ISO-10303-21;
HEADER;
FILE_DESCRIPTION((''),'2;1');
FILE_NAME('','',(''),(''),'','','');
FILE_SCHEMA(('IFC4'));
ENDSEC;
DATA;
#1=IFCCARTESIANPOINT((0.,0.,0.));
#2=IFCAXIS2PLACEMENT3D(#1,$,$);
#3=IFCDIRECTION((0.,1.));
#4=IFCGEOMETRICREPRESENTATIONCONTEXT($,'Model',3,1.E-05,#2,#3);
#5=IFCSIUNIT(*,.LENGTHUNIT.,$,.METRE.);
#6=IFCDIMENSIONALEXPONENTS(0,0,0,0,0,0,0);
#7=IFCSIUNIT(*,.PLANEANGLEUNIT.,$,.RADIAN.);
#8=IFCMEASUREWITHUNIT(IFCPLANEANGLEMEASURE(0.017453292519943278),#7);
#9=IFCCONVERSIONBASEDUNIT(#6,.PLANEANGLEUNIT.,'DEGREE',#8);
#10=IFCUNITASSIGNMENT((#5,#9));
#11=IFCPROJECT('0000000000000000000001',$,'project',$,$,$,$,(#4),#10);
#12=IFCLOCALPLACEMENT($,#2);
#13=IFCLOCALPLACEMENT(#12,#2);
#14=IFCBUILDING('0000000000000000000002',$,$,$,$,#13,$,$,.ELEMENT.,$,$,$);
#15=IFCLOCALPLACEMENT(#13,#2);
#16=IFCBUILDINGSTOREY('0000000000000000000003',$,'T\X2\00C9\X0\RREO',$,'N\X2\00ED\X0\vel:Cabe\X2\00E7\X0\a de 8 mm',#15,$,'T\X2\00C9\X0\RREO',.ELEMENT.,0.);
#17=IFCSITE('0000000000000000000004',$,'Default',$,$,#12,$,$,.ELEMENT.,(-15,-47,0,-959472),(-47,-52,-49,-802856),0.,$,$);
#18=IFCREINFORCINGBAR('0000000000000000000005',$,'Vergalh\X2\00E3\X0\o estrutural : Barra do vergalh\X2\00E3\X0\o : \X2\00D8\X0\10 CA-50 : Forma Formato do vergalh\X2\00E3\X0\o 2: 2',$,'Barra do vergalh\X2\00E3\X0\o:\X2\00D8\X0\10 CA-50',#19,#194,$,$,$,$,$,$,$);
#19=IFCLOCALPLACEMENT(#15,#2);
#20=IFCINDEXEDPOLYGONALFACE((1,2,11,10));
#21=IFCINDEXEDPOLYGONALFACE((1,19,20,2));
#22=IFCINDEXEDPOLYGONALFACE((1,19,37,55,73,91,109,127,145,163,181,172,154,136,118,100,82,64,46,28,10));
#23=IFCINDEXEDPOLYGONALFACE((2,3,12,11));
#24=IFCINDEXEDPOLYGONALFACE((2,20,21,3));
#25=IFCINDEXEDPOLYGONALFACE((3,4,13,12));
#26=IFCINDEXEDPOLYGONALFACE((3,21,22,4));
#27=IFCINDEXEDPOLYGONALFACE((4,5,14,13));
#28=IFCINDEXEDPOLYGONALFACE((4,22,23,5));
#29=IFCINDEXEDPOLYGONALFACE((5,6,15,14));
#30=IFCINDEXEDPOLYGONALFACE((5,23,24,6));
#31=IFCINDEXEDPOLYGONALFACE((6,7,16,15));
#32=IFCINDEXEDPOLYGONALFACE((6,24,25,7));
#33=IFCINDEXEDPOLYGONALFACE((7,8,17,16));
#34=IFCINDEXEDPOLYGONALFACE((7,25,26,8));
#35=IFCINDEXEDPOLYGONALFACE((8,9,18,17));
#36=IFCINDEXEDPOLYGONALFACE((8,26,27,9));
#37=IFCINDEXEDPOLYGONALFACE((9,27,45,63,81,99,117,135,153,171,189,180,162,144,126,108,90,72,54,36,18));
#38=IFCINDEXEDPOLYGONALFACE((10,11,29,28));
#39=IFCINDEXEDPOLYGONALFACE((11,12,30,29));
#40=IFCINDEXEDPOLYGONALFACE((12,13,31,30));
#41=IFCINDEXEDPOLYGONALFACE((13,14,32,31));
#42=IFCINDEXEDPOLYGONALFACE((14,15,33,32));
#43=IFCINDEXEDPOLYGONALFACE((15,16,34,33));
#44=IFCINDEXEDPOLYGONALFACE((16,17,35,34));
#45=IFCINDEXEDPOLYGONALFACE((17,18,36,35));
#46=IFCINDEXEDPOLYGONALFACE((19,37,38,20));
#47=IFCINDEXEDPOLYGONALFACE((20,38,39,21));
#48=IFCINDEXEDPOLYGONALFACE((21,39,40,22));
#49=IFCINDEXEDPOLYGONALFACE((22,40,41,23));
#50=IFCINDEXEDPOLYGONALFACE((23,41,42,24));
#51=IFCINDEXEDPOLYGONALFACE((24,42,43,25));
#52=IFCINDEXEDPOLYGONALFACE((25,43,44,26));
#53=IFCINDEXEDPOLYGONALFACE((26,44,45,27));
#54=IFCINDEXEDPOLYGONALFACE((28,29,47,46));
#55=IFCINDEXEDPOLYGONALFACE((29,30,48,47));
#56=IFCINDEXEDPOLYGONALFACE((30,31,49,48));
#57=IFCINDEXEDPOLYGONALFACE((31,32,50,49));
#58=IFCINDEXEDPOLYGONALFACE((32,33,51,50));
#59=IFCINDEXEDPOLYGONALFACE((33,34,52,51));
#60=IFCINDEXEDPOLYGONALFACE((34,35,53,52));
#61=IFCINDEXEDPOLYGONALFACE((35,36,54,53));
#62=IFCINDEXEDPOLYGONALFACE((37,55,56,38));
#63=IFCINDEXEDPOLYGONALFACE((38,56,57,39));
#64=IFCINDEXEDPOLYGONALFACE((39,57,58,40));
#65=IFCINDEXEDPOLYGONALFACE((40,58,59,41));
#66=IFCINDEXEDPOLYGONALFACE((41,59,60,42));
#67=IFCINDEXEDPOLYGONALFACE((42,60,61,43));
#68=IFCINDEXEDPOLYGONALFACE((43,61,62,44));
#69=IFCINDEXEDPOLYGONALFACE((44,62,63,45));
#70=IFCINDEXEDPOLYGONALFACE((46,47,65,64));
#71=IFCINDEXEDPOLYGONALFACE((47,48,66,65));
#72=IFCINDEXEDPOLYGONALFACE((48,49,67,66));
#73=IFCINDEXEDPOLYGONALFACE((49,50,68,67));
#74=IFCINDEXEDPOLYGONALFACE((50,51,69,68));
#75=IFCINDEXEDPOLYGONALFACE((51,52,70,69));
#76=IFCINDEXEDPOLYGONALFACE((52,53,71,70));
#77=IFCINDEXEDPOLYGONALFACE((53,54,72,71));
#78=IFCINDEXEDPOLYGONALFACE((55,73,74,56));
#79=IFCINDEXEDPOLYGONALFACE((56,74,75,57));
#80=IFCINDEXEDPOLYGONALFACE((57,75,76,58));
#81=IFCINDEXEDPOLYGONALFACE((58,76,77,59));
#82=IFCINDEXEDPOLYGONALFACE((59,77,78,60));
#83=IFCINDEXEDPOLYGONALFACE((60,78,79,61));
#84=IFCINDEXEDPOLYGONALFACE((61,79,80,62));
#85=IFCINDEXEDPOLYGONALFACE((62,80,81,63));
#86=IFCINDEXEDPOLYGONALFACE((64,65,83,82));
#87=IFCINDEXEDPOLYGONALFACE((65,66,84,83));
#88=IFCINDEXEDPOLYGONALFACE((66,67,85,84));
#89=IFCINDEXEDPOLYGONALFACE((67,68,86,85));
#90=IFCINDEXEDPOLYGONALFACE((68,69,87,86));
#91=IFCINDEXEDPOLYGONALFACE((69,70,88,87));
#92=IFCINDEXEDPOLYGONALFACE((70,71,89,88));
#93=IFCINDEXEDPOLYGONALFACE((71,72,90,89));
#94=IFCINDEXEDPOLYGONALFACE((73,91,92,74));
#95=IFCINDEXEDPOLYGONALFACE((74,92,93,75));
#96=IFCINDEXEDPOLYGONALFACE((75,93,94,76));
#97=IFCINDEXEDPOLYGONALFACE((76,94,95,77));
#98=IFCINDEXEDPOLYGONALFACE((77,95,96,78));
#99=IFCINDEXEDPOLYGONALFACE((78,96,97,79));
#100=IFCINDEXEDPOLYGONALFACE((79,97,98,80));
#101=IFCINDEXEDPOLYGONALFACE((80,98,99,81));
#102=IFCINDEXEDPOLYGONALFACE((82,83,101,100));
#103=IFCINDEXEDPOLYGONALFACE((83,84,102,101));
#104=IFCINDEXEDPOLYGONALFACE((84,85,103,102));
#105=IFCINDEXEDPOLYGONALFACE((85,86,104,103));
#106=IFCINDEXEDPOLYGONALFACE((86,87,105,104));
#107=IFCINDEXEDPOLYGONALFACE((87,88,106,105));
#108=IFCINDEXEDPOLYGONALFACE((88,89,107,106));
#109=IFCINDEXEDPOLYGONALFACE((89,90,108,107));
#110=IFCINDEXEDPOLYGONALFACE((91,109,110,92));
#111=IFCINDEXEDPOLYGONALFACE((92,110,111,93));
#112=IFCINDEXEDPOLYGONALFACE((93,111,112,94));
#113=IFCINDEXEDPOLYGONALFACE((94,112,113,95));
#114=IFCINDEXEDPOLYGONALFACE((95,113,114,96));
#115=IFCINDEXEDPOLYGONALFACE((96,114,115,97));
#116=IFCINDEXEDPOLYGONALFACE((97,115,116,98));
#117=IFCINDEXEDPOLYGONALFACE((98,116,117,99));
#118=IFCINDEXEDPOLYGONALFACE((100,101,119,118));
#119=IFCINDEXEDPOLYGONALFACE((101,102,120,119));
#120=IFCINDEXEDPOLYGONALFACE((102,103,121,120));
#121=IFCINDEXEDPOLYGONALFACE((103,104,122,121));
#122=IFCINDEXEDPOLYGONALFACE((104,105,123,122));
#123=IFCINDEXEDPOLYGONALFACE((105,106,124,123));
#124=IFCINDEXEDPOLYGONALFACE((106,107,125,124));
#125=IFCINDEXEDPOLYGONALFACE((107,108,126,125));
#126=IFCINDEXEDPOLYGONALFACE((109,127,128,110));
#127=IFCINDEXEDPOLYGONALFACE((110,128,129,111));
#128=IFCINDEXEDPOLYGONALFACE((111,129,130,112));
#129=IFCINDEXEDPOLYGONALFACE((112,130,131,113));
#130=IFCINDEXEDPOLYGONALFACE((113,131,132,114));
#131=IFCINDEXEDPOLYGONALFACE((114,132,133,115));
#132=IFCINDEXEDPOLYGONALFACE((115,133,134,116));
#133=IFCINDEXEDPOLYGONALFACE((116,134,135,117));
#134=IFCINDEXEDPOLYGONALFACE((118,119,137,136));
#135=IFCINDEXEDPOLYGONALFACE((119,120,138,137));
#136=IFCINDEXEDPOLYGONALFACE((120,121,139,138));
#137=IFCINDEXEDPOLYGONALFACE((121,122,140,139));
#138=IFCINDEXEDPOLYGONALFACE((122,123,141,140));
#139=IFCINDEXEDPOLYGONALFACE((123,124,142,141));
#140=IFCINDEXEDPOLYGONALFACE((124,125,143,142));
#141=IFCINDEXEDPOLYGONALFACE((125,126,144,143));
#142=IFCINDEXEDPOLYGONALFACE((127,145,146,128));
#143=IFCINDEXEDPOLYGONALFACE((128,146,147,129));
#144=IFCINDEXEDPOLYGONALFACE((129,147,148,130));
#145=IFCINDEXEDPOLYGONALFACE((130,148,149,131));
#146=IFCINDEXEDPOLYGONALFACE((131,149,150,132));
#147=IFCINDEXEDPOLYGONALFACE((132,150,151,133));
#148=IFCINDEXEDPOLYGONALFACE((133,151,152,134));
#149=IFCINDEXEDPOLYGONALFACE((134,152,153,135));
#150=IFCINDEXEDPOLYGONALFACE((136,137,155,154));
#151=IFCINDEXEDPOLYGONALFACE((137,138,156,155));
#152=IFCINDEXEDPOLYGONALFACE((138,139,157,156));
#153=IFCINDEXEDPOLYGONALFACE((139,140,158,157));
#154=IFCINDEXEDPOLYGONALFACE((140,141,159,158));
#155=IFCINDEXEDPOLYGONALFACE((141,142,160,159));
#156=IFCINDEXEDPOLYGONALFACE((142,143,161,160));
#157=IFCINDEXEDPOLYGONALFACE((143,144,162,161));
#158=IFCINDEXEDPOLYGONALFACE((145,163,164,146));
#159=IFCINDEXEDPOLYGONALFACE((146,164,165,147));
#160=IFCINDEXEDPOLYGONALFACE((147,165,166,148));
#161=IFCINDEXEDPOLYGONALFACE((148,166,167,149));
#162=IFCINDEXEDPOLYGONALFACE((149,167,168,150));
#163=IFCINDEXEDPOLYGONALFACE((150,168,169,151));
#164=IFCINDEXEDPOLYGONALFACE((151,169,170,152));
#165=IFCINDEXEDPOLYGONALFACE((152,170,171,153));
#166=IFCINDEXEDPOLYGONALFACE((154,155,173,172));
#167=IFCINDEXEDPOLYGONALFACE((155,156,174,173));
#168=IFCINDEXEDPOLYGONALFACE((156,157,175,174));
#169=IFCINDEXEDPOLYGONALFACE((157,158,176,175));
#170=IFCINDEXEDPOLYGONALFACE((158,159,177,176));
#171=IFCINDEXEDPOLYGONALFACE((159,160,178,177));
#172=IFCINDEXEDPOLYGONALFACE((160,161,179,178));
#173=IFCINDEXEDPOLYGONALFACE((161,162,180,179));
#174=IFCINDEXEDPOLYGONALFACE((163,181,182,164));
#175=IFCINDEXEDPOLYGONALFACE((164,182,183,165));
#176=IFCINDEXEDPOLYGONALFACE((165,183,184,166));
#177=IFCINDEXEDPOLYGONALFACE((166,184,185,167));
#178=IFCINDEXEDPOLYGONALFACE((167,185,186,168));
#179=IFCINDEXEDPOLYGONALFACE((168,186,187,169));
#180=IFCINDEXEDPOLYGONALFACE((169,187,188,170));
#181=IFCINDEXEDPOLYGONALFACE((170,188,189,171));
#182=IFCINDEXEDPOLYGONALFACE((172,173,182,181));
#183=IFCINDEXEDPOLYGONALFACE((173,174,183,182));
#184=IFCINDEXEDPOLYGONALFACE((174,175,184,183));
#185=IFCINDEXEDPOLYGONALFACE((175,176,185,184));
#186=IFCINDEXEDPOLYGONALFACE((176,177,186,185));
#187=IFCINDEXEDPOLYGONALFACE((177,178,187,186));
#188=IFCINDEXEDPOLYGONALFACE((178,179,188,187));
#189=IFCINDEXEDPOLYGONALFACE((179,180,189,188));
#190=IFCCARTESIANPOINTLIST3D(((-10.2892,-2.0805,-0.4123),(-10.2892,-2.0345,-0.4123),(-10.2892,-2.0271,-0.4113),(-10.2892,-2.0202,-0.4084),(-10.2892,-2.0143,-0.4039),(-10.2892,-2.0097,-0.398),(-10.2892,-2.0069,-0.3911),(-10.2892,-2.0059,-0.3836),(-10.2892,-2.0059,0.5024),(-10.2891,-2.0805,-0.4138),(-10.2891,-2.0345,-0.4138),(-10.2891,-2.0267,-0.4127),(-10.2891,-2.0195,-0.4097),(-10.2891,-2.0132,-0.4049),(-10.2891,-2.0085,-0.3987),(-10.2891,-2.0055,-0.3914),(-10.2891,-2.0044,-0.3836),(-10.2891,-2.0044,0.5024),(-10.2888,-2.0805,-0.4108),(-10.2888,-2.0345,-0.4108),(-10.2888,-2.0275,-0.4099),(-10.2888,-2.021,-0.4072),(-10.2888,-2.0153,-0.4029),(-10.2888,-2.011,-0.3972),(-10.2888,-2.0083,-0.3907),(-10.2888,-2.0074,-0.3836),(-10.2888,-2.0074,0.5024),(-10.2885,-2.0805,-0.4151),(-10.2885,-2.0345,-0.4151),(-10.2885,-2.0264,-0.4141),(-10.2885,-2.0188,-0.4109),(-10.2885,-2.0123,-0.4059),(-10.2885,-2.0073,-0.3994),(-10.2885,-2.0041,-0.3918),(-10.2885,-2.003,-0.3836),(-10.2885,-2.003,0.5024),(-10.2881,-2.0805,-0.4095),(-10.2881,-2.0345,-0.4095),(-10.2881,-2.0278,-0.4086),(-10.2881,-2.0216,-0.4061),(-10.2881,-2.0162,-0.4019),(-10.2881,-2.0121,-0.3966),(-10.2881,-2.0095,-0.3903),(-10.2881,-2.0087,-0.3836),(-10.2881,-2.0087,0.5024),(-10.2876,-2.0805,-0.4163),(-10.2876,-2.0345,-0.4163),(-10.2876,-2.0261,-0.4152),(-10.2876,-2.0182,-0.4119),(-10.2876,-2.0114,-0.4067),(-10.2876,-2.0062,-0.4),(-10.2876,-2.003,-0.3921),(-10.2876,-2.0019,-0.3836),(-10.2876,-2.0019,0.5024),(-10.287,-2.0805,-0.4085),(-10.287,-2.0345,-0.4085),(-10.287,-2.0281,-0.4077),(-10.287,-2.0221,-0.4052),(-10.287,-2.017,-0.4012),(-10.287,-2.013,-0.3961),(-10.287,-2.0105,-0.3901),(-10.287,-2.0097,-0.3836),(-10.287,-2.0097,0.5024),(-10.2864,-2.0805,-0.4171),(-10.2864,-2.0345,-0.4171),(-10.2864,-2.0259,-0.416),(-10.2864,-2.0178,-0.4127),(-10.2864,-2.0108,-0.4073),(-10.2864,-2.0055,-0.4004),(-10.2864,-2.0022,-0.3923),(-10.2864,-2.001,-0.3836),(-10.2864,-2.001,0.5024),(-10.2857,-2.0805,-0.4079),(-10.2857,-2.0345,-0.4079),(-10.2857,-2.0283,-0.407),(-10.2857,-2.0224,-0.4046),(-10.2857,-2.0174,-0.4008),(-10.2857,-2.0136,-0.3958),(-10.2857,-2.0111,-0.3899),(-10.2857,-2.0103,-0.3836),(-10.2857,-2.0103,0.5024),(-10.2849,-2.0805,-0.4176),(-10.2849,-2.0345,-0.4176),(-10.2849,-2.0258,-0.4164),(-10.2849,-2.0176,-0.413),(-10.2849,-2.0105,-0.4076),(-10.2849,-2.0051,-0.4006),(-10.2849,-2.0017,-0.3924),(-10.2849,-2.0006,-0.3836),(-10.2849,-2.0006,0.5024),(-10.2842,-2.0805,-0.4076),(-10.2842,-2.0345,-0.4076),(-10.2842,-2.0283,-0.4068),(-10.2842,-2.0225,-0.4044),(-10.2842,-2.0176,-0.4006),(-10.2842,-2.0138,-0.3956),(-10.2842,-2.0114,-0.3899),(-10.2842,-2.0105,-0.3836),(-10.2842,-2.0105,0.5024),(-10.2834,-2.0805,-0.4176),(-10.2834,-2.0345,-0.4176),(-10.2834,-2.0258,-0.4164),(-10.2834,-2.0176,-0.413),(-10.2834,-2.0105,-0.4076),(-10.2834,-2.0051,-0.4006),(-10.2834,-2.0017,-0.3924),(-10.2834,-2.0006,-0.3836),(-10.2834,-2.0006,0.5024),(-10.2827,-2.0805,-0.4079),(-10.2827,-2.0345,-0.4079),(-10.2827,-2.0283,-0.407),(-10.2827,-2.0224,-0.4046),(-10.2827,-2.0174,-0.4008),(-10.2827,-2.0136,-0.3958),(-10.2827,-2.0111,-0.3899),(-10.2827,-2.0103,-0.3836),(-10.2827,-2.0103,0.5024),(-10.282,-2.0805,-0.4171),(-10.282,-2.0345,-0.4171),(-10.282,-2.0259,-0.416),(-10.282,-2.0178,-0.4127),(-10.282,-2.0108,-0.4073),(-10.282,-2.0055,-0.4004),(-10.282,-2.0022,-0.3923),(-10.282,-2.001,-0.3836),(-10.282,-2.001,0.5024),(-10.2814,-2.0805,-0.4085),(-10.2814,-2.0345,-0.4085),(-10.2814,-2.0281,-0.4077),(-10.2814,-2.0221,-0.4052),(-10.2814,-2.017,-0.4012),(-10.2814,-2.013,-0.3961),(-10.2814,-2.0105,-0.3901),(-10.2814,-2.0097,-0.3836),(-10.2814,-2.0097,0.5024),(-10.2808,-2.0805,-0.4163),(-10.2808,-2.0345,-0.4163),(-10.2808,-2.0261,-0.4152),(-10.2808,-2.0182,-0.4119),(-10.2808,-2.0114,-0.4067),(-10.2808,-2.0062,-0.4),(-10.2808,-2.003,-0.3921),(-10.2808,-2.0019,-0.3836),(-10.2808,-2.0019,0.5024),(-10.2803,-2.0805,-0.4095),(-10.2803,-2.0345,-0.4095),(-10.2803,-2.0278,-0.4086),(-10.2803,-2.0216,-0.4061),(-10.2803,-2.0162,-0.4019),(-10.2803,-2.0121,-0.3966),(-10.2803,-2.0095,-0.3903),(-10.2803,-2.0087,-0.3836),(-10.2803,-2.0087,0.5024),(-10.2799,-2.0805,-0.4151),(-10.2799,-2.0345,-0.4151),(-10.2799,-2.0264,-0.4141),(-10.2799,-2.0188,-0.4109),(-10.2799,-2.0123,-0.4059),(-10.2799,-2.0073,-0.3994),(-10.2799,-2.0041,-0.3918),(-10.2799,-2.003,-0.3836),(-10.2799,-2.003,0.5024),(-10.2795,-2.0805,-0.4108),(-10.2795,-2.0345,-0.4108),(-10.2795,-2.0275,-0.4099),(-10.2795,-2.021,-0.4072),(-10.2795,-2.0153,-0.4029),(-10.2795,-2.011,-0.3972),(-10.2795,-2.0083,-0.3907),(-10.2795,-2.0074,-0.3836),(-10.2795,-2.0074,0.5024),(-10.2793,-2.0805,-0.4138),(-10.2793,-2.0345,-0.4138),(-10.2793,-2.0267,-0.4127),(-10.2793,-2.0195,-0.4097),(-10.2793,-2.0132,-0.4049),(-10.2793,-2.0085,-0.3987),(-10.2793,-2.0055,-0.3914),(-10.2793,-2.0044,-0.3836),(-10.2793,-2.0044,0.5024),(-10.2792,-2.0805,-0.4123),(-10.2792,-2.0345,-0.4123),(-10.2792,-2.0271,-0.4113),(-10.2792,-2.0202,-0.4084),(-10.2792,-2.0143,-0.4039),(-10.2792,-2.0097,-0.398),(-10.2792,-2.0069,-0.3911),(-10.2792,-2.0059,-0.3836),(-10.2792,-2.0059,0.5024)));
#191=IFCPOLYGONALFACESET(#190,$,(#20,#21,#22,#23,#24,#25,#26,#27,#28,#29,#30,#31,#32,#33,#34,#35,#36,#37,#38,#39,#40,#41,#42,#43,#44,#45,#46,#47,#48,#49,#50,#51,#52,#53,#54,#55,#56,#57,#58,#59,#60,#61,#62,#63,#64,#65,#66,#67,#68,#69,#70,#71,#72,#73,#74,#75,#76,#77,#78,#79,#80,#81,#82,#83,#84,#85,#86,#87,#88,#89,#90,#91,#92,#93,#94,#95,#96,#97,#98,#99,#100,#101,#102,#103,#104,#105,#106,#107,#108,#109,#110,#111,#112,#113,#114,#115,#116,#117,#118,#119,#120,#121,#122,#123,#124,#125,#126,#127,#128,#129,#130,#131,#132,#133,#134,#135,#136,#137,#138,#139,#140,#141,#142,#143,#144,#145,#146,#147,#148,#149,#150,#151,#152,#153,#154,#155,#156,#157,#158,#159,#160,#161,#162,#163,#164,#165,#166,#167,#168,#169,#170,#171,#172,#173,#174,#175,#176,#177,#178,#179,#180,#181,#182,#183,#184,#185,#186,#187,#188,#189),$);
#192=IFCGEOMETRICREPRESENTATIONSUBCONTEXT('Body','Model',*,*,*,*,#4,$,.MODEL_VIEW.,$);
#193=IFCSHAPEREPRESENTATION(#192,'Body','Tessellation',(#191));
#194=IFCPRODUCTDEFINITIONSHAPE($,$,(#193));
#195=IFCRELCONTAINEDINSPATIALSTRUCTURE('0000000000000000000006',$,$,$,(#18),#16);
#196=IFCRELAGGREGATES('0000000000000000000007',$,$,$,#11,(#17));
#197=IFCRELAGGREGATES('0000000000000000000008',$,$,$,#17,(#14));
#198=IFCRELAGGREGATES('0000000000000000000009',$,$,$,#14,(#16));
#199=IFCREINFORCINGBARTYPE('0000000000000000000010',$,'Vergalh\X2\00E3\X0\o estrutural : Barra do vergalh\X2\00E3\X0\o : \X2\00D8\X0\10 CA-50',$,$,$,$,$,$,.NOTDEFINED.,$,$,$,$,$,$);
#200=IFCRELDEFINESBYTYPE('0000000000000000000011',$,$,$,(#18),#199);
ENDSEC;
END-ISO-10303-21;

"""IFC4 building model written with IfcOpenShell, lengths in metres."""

from ifc_helpers import new_model, entity, si_unit, converted_unit, direction, origin, place, context, subcontext, project, spatial, type_object, element, save


model = new_model("IFC4")

# Units and contexts
model_context = context("Model", 3, precision=1e-05, world=origin(), true_north=direction((0.0, 1.0)))
body_context = subcontext(model_context, "Body", "Model", "MODEL_VIEW")
ifc_project = project(units=[si_unit("LENGTHUNIT", "METRE"), converted_unit("PLANEANGLEUNIT", "DEGREE", entity("IfcPlaneAngleMeasure", 0.017453292519943278), si_unit("PLANEANGLEUNIT", "RADIAN"), dimensions=[0, 0, 0, 0, 0, 0, 0])], contexts=[model_context])

# Site, building, storey
site_placement = place(None, origin())
site = spatial("IfcSite", under=ifc_project, at=site_placement, Name="Default", CompositionType="ELEMENT", RefLatitude=(-15, -47, 0, -959472), RefLongitude=(-47, -52, -49, -802856), RefElevation=0.0)
building_placement = place(site_placement, origin())
building = spatial("IfcBuilding", under=site, at=building_placement, CompositionType="ELEMENT")
storey_placement = place(building_placement, origin())
storey = spatial("IfcBuildingStorey", under=building, at=storey_placement, Name="TÉRREO", ObjectType="Nível:Cabeça de 8 mm", LongName="TÉRREO", CompositionType="ELEMENT", Elevation=0.0)

# Reinforcing bar
reinforcing_bar_type_1 = type_object("IfcReinforcingBarType", Name="Vergalhão estrutural : Barra do vergalhão : Ø10 CA-50", PredefinedType="NOTDEFINED")
reinforcing_bar_1_placement = place(storey_placement, origin())
element("IfcReinforcingBar", 1, at=reinforcing_bar_1_placement, inside=storey, type_object=reinforcing_bar_type_1, Name="Vergalhão estrutural : Barra do vergalhão : Ø10 CA-50 : Forma Formato do vergalhão 2: 2", ObjectType="Barra do vergalhão:Ø10 CA-50", context=body_context, shape_type="AdvancedSweptSolid", body=[
    entity("IfcSweptDiskSolid", entity("IfcIndexedPolyCurve", entity("IfcCartesianPointList3D", [[-10.2842, -2.0805, -0.4126], [-10.2842, -2.0345, -0.4126], [-10.2842, -2.014, -0.4042], [-10.2842, -2.0055, -0.3836], [-10.2842, -2.0055, 0.5024]]), [entity("IfcLineIndex", [1, 2]), entity("IfcArcIndex", [2, 3, 4]), entity("IfcLineIndex", [4, 5])], False), 0.005, None, 0.0, 92.0),
])

save(model, "model.ifc")
